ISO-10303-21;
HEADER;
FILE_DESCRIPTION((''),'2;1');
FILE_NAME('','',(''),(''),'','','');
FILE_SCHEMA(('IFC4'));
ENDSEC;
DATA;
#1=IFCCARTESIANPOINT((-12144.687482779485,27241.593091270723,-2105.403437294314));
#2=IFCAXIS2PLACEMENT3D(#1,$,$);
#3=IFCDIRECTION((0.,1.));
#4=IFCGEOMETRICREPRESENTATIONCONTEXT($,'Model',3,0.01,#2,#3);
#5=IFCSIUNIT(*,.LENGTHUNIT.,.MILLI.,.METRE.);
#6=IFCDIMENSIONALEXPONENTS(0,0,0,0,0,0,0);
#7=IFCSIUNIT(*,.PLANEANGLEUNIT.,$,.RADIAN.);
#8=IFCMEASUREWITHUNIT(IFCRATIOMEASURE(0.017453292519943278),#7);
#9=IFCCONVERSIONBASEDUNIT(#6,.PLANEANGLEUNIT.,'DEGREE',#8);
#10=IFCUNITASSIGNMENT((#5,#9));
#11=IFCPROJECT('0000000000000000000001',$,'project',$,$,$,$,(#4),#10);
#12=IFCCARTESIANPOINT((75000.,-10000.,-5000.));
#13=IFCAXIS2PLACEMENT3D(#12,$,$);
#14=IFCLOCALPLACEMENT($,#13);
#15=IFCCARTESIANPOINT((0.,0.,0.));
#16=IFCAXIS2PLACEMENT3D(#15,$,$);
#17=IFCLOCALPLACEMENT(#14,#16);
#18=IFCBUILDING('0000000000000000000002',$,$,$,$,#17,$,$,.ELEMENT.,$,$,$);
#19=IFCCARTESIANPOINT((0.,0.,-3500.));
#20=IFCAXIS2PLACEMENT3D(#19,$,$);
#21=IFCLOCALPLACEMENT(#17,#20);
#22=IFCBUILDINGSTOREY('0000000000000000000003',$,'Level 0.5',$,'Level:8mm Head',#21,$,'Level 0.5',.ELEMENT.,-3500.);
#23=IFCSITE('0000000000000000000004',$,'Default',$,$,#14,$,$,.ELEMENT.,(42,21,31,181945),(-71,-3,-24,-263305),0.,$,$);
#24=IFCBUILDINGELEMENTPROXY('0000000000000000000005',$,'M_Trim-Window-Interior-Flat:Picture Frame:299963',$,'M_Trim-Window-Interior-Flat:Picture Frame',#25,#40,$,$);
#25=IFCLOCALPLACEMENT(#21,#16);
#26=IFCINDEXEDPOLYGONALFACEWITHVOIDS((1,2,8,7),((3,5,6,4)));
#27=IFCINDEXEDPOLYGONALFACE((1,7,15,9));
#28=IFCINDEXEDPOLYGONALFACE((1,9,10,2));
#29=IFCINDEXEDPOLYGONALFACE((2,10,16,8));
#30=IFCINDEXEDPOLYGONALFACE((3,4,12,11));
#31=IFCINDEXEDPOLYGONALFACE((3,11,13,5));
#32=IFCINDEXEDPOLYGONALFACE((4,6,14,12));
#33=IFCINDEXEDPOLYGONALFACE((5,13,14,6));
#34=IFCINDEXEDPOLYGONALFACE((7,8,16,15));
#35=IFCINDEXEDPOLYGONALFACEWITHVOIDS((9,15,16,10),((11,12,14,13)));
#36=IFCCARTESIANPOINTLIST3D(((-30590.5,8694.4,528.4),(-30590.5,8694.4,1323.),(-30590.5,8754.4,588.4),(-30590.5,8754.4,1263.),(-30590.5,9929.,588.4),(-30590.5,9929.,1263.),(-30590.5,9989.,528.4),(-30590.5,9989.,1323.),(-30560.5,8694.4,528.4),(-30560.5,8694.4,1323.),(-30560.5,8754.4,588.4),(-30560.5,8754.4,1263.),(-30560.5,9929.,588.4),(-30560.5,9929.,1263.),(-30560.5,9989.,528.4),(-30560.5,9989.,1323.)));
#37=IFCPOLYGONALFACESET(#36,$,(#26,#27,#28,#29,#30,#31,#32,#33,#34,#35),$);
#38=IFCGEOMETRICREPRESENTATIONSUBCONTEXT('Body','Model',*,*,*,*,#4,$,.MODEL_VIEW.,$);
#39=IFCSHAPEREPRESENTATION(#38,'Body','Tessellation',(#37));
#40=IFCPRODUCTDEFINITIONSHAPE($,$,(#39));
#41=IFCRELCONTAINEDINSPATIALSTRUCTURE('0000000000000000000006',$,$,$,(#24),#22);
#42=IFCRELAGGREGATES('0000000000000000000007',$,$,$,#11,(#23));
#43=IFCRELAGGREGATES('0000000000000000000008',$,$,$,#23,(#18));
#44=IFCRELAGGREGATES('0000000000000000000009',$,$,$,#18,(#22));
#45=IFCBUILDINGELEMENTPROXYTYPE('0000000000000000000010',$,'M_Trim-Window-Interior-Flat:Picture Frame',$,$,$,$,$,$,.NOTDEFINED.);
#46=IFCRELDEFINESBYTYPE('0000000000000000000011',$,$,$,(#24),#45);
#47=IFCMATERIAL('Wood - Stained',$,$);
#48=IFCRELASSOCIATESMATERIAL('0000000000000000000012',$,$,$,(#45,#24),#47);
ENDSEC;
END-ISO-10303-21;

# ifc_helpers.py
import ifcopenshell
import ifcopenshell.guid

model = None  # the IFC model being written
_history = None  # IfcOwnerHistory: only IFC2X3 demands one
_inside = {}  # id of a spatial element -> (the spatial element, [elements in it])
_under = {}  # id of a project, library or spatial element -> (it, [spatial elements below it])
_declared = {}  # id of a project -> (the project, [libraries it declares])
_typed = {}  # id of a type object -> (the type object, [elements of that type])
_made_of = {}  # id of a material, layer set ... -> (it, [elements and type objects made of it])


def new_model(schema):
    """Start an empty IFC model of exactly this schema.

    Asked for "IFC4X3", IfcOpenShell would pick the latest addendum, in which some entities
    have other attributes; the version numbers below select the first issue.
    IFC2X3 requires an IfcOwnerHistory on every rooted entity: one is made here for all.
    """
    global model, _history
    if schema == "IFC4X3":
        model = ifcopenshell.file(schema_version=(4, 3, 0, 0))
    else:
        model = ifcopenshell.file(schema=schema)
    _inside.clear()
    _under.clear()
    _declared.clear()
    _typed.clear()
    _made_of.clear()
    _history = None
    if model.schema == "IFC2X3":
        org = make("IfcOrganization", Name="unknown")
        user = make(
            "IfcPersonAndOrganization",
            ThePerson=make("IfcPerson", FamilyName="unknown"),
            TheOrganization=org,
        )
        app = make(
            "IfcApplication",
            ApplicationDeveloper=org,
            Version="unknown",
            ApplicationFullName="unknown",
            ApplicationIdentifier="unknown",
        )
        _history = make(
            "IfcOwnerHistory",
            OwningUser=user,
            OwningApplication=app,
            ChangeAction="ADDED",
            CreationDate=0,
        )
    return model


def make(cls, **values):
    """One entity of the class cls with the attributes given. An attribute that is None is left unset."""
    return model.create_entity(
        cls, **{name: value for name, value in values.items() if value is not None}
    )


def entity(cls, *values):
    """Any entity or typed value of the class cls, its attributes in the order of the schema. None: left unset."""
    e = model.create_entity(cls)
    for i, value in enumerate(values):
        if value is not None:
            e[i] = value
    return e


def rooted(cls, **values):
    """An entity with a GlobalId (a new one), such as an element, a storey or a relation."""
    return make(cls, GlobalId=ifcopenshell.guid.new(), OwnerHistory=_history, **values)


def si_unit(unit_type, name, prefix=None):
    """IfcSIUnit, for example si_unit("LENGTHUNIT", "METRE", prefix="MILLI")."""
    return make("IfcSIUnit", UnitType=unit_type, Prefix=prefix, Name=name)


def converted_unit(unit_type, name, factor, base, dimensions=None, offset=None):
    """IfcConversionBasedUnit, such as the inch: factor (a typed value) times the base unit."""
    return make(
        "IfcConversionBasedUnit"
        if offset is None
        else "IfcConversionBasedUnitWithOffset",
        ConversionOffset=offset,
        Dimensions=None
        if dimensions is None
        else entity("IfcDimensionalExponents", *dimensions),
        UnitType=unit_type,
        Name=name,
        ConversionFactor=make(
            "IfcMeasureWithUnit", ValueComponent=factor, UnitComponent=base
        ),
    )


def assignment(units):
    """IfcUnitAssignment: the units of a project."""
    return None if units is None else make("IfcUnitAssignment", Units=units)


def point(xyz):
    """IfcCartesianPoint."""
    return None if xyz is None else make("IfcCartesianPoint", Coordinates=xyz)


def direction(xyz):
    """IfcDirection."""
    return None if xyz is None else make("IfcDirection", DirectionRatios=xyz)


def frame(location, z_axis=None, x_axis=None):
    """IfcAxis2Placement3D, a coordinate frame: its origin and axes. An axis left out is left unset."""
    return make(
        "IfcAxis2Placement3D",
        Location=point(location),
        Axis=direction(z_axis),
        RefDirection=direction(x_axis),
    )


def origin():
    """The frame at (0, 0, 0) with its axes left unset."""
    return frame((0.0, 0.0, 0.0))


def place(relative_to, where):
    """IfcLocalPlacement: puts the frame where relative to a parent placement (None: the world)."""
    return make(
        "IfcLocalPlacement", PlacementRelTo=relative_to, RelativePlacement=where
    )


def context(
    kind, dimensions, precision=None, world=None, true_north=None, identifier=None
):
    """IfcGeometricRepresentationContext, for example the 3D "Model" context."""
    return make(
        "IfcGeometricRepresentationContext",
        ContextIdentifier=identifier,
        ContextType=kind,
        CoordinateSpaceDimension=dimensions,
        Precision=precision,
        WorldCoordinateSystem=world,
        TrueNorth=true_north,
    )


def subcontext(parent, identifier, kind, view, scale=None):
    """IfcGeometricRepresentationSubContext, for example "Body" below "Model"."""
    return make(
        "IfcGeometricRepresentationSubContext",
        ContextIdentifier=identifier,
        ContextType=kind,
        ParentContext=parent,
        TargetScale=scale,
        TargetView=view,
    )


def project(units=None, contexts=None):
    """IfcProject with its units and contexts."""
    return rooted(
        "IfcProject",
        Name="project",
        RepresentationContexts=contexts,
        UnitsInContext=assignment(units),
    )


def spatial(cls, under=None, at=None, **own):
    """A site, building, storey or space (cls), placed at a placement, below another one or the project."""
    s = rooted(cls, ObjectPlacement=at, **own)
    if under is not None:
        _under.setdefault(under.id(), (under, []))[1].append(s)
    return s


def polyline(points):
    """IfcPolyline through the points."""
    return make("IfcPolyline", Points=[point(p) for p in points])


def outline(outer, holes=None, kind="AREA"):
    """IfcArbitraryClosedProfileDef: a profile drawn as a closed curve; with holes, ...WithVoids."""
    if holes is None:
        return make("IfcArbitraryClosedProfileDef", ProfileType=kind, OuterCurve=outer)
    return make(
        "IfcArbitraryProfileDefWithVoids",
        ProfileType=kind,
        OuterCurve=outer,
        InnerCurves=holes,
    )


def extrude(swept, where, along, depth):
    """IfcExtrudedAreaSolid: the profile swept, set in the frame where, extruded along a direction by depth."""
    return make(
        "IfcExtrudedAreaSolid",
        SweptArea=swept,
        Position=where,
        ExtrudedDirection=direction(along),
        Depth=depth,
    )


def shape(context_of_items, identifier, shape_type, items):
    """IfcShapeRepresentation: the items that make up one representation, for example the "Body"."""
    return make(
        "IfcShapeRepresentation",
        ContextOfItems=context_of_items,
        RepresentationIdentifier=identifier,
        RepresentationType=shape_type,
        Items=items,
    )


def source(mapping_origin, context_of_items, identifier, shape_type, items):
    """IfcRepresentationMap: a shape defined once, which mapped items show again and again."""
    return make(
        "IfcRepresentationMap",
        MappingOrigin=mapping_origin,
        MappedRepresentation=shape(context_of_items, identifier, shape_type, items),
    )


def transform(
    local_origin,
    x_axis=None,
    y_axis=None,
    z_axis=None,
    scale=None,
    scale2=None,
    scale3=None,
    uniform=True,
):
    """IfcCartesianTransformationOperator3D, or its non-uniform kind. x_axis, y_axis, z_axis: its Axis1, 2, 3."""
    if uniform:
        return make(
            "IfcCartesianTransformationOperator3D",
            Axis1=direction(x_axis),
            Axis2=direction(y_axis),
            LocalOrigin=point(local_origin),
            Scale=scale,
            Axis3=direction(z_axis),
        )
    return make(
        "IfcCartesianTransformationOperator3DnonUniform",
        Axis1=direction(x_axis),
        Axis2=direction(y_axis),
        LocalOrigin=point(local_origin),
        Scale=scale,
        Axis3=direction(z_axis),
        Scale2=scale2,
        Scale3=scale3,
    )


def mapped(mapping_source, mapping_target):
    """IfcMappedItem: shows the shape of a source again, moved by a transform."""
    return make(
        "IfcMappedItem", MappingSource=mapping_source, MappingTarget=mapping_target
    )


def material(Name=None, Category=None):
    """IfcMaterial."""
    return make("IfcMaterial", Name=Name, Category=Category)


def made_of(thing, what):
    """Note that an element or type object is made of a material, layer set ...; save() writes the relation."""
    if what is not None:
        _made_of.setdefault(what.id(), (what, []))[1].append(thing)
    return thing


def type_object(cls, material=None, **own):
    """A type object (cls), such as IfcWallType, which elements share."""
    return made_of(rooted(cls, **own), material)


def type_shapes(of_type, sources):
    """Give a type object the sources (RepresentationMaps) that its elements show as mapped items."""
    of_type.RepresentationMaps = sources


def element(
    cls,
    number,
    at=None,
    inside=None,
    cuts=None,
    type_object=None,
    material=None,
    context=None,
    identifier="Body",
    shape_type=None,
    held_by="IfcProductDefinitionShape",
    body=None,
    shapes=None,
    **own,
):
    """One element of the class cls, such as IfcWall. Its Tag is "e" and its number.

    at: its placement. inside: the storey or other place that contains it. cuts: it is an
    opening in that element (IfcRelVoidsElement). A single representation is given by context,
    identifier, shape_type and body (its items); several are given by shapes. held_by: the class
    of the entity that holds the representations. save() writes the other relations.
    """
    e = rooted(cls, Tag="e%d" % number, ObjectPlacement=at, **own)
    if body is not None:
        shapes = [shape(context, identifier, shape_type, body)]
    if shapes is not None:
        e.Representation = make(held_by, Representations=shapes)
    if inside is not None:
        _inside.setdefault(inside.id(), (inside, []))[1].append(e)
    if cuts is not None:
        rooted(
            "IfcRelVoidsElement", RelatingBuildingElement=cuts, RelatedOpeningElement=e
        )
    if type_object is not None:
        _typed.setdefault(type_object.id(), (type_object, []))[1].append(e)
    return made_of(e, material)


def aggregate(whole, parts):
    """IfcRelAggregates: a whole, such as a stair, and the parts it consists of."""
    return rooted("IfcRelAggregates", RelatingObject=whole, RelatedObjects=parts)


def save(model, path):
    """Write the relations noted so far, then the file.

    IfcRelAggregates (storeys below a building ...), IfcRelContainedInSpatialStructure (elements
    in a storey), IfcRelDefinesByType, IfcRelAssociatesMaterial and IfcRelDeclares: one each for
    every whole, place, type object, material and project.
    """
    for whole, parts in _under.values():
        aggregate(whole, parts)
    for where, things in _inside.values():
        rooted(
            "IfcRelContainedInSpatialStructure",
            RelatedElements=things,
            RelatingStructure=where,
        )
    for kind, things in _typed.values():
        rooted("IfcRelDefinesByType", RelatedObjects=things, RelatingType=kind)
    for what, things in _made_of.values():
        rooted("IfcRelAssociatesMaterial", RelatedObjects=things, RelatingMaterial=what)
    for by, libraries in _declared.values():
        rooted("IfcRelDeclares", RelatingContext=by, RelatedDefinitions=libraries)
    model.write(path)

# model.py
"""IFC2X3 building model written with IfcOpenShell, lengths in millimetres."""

from ifc_helpers import new_model, entity, si_unit, converted_unit, direction, frame, origin, place, context, subcontext, project, spatial, polyline, outline, extrude, source, transform, mapped, material, type_object, type_shapes, element, save


model = new_model("IFC2X3")

# Units and contexts
model_context = context("Model", 3, precision=0.01, world=frame((-12144.687482779485, 27241.593091270723, -2105.403437294314)), true_north=direction((0.0, 1.0)))
body_context = subcontext(model_context, "Body", "Model", "MODEL_VIEW")
ifc_project = project(units=[si_unit("LENGTHUNIT", "METRE", prefix="MILLI"), converted_unit("PLANEANGLEUNIT", "DEGREE", entity("IfcRatioMeasure", 0.017453292519943278), si_unit("PLANEANGLEUNIT", "RADIAN"), dimensions=[0, 0, 0, 0, 0, 0, 0])], contexts=[model_context])

# Site, building, storey
site_placement = place(None, frame((75000.0, -10000.0, -5000.0)))
site = spatial("IfcSite", under=ifc_project, at=site_placement, Name="Default", CompositionType="ELEMENT", RefLatitude=(42, 21, 31, 181945), RefLongitude=(-71, -3, -24, -263305), RefElevation=0.0)
building_placement = place(site_placement, origin())
building = spatial("IfcBuilding", under=site, at=building_placement, CompositionType="ELEMENT")
storey_placement = place(building_placement, frame((0.0, 0.0, -3500.0)))
storey = spatial("IfcBuildingStorey", under=building, at=storey_placement, Name="Level 0.5", ObjectType="Level:8mm Head", LongName="Level 0.5", CompositionType="ELEMENT", Elevation=-3500.0)

# Building element proxy
ifc_material_1 = material(Name="Wood - Stained")
building_element_proxy_type_1 = type_object("IfcBuildingElementProxyType", Name="M_Trim-Window-Interior-Flat:Picture Frame", PredefinedType="NOTDEFINED", material=ifc_material_1)
shared_shape_1 = source(origin(), body_context, "Body", "SweptSolid", [
    extrude(outline(polyline([(-647.3, -397.3), (647.3, -397.3), (647.3, 397.3), (-647.3, 397.3), (-647.3, -397.3)]), holes=[polyline([(-587.3, -337.3), (-587.3, 337.3), (587.3, 337.3), (587.3, -337.3), (-587.3, -337.3)])]), frame((0.0, -350.0, 0.0), z_axis=(0.0, 0.0, 1.0), x_axis=(-1.0, 0.0, 0.0)), (0.0, 0.0, 1.0), 30.0),
])
type_shapes(building_element_proxy_type_1, [shared_shape_1])
proxy_1_placement = place(storey_placement, frame((-30560.5, 9341.7, 1275.7), z_axis=(-1.0, 0.0, 0.0), x_axis=(0.0, -1.0, 0.0)))
element("IfcBuildingElementProxy", 1, at=proxy_1_placement, inside=storey, type_object=building_element_proxy_type_1, material=ifc_material_1, Name="M_Trim-Window-Interior-Flat:Picture Frame:299963", ObjectType="M_Trim-Window-Interior-Flat:Picture Frame", context=body_context, shape_type="MappedRepresentation", body=[
    mapped(shared_shape_1, transform((0.0, 0.0, 0.0), scale=1.0)),
])

save(model, "model.ifc")
